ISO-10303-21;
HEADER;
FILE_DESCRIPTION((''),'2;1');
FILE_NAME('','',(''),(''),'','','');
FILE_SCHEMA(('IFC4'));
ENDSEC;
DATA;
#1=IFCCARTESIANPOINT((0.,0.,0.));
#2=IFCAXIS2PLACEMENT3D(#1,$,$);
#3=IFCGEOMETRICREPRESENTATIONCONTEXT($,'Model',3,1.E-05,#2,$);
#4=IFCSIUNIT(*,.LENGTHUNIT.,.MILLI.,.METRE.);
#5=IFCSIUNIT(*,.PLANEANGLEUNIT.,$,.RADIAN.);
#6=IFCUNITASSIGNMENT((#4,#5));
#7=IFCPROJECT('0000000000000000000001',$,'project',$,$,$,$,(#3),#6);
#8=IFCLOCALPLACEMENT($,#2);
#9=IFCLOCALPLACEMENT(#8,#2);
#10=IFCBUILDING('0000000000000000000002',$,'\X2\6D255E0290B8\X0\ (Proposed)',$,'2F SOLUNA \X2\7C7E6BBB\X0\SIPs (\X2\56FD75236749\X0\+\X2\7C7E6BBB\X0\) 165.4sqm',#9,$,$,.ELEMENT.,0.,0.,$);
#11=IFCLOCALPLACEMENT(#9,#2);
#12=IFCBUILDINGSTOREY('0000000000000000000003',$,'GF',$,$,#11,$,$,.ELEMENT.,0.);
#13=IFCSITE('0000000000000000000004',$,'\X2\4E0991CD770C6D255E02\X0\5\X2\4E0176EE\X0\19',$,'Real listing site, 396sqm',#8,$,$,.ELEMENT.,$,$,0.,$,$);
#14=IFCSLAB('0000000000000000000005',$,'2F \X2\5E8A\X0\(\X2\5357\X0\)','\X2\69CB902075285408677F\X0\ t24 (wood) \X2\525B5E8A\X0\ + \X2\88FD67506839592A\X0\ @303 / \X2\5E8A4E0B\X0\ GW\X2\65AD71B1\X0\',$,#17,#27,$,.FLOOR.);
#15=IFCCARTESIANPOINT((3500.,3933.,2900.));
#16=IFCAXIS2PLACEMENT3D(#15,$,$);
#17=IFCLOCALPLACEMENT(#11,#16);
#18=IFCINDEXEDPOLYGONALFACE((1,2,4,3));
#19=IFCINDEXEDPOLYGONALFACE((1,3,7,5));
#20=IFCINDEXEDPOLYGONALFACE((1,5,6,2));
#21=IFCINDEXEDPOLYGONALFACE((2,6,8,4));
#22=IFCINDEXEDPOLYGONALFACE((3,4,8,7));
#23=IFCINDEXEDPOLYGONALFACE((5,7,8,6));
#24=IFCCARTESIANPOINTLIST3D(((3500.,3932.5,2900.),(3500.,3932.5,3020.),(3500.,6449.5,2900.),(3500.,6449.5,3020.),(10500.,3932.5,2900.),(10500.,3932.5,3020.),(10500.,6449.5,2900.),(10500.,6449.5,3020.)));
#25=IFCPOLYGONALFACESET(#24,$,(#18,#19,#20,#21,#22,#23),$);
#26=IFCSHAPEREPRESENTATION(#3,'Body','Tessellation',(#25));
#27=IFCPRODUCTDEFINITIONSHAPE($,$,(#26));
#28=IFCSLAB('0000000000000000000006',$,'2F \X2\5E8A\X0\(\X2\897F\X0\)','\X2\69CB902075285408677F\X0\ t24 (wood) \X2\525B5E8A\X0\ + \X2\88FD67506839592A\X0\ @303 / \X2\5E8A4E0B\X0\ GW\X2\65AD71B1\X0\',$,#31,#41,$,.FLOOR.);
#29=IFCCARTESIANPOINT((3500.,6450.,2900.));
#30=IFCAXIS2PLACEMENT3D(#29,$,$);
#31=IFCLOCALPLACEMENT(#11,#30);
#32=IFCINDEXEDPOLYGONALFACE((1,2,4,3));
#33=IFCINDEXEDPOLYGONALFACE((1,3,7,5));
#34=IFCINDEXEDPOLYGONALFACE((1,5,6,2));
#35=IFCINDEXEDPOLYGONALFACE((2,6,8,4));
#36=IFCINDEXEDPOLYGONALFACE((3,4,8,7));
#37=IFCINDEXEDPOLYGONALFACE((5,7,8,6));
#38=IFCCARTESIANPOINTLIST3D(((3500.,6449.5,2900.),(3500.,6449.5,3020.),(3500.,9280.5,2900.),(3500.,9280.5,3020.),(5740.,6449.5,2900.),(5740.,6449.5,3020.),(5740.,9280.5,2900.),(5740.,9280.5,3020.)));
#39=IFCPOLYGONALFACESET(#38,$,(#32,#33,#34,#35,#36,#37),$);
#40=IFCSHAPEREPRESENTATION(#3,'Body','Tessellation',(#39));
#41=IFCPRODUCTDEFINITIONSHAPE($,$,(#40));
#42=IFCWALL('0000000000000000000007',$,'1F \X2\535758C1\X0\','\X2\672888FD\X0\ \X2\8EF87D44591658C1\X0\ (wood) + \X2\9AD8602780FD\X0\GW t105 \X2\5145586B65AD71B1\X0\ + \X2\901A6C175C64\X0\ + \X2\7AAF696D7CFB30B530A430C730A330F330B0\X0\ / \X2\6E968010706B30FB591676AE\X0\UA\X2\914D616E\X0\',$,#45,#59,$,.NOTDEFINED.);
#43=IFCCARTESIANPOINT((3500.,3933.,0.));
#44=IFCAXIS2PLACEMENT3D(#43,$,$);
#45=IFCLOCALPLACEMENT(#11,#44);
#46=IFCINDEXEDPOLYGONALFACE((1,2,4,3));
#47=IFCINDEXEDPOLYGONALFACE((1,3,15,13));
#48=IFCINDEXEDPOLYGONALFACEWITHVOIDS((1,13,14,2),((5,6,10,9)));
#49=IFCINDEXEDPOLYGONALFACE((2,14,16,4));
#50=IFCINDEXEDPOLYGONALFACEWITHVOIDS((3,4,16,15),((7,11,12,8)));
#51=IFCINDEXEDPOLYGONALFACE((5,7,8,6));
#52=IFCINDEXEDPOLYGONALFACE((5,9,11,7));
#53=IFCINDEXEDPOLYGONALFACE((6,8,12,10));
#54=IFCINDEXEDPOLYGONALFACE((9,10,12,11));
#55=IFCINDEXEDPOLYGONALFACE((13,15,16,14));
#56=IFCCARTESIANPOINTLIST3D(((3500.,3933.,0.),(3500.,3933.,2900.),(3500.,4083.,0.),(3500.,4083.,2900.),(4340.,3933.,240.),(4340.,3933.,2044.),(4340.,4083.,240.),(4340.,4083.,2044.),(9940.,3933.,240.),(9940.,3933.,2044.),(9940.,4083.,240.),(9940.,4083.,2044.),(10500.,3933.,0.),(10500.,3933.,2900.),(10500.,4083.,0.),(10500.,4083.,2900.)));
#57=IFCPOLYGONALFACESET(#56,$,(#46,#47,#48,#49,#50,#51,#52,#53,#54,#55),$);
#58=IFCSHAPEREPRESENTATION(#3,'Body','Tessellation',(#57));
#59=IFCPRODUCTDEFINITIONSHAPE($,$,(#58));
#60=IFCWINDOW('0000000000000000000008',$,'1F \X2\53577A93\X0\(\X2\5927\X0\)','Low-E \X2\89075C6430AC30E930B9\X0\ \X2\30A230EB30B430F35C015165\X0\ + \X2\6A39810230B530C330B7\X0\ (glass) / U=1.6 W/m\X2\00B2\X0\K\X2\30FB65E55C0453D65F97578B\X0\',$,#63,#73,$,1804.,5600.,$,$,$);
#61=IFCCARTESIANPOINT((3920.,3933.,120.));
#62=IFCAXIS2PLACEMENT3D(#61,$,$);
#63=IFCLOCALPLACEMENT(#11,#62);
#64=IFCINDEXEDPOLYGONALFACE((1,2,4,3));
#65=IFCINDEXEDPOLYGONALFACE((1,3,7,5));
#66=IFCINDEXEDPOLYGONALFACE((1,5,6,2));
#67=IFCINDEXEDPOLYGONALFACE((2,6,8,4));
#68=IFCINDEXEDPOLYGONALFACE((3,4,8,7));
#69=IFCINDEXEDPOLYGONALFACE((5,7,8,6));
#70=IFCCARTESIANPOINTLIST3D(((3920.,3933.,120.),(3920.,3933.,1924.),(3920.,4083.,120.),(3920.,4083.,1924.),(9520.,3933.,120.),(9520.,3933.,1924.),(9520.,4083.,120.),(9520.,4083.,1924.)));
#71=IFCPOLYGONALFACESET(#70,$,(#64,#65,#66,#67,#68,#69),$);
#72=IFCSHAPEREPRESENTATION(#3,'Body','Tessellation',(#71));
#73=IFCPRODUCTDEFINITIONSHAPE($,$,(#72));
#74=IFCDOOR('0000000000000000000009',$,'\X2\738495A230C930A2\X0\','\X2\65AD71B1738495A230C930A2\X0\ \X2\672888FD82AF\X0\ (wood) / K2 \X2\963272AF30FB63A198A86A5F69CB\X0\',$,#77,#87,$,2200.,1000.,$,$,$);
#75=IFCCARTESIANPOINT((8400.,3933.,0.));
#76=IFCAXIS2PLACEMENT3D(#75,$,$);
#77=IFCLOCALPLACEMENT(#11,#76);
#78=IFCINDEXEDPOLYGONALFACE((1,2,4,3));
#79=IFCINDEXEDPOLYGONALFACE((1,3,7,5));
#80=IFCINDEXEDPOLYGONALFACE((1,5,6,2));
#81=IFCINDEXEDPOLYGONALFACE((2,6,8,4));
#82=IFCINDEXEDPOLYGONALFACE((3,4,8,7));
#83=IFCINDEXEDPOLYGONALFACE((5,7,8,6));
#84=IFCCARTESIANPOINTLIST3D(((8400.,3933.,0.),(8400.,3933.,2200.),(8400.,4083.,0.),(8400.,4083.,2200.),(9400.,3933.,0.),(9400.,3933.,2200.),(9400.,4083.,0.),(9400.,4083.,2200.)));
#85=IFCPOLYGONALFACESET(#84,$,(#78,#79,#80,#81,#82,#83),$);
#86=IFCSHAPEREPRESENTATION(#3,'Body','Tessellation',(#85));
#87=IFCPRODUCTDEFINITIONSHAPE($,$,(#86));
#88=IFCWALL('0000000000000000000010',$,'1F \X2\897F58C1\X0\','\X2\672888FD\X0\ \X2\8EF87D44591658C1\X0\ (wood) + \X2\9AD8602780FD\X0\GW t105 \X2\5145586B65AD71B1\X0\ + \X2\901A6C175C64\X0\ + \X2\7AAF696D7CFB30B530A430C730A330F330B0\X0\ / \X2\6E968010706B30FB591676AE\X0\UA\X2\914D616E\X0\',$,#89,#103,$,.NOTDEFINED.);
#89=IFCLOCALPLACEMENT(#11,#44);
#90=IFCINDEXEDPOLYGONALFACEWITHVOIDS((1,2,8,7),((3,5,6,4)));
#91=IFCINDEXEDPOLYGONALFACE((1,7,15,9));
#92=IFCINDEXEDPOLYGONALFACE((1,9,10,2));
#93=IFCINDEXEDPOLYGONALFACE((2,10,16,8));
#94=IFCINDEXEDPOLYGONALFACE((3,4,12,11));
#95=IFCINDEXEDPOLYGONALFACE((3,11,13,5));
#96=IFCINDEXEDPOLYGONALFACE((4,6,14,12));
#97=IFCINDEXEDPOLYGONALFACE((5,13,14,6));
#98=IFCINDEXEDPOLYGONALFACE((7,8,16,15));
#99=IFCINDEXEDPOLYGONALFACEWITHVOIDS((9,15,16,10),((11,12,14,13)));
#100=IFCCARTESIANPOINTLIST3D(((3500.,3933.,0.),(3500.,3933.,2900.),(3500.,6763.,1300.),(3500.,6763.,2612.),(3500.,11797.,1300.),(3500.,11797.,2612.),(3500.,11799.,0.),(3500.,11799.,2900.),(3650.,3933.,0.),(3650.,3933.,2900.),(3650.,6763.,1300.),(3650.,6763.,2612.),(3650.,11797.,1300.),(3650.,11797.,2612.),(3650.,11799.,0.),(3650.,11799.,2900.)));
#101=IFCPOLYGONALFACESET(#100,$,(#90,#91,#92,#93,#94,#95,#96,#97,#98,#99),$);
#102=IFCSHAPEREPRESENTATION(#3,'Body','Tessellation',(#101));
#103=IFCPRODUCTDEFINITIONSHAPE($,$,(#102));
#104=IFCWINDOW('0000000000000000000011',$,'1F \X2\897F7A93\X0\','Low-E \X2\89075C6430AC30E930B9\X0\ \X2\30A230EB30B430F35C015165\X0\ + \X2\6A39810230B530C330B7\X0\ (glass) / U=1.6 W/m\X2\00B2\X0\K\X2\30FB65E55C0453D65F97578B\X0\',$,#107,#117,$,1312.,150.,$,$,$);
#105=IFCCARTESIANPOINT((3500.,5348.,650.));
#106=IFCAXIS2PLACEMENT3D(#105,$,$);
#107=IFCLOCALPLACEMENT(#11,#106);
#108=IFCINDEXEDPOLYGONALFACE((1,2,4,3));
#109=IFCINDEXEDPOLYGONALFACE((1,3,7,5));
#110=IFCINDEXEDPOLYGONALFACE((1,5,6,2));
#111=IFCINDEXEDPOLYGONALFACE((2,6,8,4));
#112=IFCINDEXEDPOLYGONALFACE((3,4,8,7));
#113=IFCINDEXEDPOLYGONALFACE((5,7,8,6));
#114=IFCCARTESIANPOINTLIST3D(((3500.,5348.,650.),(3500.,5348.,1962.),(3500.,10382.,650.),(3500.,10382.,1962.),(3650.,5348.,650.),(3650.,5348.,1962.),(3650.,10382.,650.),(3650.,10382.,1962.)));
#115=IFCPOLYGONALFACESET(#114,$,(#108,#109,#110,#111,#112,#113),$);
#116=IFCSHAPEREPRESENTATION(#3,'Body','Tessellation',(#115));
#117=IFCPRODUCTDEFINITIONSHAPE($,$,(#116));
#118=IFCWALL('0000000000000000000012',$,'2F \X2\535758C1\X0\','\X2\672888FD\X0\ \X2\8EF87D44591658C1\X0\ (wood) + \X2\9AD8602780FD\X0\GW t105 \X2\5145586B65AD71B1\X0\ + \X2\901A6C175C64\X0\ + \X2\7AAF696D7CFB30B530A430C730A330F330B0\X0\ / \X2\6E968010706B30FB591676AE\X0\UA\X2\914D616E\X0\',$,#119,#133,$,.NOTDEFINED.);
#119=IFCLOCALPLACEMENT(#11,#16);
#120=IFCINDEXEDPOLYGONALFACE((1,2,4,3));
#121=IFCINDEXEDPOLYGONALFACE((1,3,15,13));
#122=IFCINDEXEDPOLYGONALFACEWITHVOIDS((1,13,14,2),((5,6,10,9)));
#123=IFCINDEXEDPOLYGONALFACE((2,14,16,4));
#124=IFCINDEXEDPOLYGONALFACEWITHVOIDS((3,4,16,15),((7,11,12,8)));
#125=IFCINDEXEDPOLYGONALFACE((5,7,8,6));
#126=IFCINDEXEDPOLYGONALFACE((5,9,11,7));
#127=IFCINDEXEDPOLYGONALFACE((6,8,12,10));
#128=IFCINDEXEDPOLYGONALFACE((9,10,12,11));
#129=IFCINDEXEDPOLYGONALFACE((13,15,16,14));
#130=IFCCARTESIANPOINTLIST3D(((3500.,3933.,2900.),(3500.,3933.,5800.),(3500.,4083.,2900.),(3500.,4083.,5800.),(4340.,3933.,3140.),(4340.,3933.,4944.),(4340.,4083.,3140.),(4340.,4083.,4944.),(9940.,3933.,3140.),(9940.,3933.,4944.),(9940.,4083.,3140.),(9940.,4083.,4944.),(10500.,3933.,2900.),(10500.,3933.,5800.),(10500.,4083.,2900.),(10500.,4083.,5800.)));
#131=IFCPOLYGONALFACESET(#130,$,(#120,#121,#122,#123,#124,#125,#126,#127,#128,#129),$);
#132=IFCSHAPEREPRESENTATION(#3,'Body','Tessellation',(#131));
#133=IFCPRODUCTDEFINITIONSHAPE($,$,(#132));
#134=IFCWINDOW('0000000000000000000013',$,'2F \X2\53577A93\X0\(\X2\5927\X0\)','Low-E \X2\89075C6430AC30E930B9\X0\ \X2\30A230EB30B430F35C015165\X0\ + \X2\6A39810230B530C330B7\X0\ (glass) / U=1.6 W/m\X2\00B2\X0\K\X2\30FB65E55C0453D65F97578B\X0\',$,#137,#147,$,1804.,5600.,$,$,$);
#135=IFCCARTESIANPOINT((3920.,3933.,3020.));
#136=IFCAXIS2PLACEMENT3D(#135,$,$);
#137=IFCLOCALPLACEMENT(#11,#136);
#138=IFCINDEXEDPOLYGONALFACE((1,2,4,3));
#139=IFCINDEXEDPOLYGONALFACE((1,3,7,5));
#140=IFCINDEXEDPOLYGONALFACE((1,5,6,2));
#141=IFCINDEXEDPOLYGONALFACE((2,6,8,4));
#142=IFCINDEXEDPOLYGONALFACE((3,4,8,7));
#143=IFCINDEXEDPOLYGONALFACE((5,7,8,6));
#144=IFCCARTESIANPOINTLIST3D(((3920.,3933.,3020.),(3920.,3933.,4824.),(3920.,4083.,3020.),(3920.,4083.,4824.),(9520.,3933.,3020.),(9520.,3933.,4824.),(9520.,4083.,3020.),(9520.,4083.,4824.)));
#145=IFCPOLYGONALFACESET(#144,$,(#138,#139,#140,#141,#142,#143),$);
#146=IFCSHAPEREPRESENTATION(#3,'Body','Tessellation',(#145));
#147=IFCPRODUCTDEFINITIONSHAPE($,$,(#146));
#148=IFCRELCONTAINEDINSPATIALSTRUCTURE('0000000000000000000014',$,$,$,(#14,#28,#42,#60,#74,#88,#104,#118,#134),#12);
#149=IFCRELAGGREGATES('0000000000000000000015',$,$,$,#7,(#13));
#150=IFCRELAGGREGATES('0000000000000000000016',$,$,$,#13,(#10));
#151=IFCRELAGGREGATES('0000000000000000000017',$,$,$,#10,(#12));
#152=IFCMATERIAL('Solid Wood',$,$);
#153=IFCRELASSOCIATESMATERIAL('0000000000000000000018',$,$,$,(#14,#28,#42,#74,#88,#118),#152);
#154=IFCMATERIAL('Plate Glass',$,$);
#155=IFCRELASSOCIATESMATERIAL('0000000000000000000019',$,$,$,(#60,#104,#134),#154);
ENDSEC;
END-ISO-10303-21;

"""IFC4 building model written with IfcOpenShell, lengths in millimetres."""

from ifc_helpers import new_model, si_unit, frame, frame_2d, origin, place, context, project, spatial, rectangle, extrude, material, element, fill, save


model = new_model("IFC4")

# Units and contexts
model_context = context("Model", 3, precision=1e-05, world=origin())
ifc_project = project(units=[si_unit("LENGTHUNIT", "METRE", prefix="MILLI"), si_unit("PLANEANGLEUNIT", "RADIAN")], contexts=[model_context])

# Site, building, storey
site_placement = place(None, origin())
site = spatial("IfcSite", under=ifc_project, at=site_placement, Name="三重県津市5丁目19", ObjectType="Real listing site, 396sqm", CompositionType="ELEMENT", RefElevation=0.0)
building_placement = place(site_placement, origin())
building = spatial("IfcBuilding", under=site, at=building_placement, Name="津市邸 (Proposed)", ObjectType="2F SOLUNA 籾殻SIPs (国産杉+籾殻) 165.4sqm", CompositionType="ELEMENT", ElevationOfRefHeight=0.0, ElevationOfTerrain=0.0)
storey_placement = place(building_placement, origin())
storey = spatial("IfcBuildingStorey", under=building, at=storey_placement, Name="GF", CompositionType="ELEMENT", Elevation=0.0)

# Slabs
ifc_material_1 = material(Name="Solid Wood")
slab_1_placement = place(storey_placement, frame((3500.0, 3933.0, 2900.0)))
element("IfcSlab", 1, at=slab_1_placement, inside=storey, material=ifc_material_1, Name="2F 床(南)", Description="構造用合板 t24 (wood) 剛床 + 製材根太 @303 / 床下 GW断熱", PredefinedType="FLOOR", context=model_context, shape_type="SweptSolid", body=[
    extrude(rectangle(XDim=7000.0, YDim=2517.0, at=frame_2d((3500.0, 1258.0))), frame((3500.0, 3933.0, 2900.0)), (0.0, 0.0, 1.0), 120.0),
])
slab_2_placement = place(storey_placement, frame((3500.0, 6450.0, 2900.0)))
element("IfcSlab", 2, at=slab_2_placement, inside=storey, material=ifc_material_1, Name="2F 床(西)", Description="構造用合板 t24 (wood) 剛床 + 製材根太 @303 / 床下 GW断熱", PredefinedType="FLOOR", context=model_context, shape_type="SweptSolid", body=[
    extrude(rectangle(XDim=2240.0, YDim=2831.0, at=frame_2d((1120.0, 1415.0))), frame((3500.0, 6450.0, 2900.0)), (0.0, 0.0, 1.0), 120.0),
])

# Wall, openings, window, door
wall_1_placement = place(storey_placement, frame((3500.0, 3933.0, 0.0)))
wall_1 = element("IfcWall", 3, at=wall_1_placement, inside=storey, material=ifc_material_1, Name="1F 南壁", Description="木製 軸組外壁 (wood) + 高性能GW t105 充填断熱 + 通気層 + 窯業系サイディング / 準耐火・外皮UA配慮", PredefinedType="NOTDEFINED", context=model_context, shape_type="SweptSolid", body=[
    extrude(rectangle(XDim=7000.0, YDim=150.0, at=frame_2d((3500.0, 75.0))), frame((3500.0, 3933.0, 0.0)), (0.0, 0.0, 1.0), 2900.0),
])
opening_1_placement = place(storey_placement, frame((3920.0, 3933.0, 120.0)))
opening_1 = element("IfcOpeningElement", 4, at=opening_1_placement, cuts=wall_1, PredefinedType="NOTDEFINED", context=model_context, shape_type="SweptSolid", body=[
    extrude(rectangle(XDim=5600.0, YDim=150.0, at=frame_2d((2800.0, 75.0))), frame((3920.0, 3933.0, 120.0)), (0.0, 0.0, 1.0), 1804.0),
])
opening_2_placement = place(storey_placement, frame((8400.0, 3933.0, 0.0)))
opening_2 = element("IfcOpeningElement", 5, at=opening_2_placement, cuts=wall_1, PredefinedType="NOTDEFINED", context=model_context, shape_type="SweptSolid", body=[
    extrude(rectangle(XDim=1000.0, YDim=150.0, at=frame_2d((500.0, 75.0))), frame((8400.0, 3933.0, 0.0)), (0.0, 0.0, 1.0), 2200.0),
])
ifc_material_2 = material(Name="Plate Glass")
window_1_placement = place(storey_placement, frame((3920.0, 3933.0, 120.0)))
window_1 = element("IfcWindow", 6, at=window_1_placement, inside=storey, material=ifc_material_2, Name="1F 南窓(大)", Description="Low-E 複層ガラス アルゴン封入 + 樹脂サッシ (glass) / U=1.6 W/m²K・日射取得型", OverallHeight=1804.0, OverallWidth=5600.0, context=model_context, shape_type="SweptSolid", body=[
    extrude(rectangle(XDim=5600.0, YDim=150.0, at=frame_2d((2800.0, 75.0))), frame((3920.0, 3933.0, 120.0)), (0.0, 0.0, 1.0), 1804.0),
])
fill(opening_1, window_1)
door_placement = place(storey_placement, frame((8400.0, 3933.0, 0.0)))
door = element("IfcDoor", 7, at=door_placement, inside=storey, material=ifc_material_1, Name="玄関ドア", Description="断熱玄関ドア 木製芯 (wood) / K2 防犯・採風機構", OverallHeight=2200.0, OverallWidth=1000.0, context=model_context, shape_type="SweptSolid", body=[
    extrude(rectangle(XDim=1000.0, YDim=150.0, at=frame_2d((500.0, 75.0))), frame((8400.0, 3933.0, 0.0)), (0.0, 0.0, 1.0), 2200.0),
])
fill(opening_2, door)

# Walls, openings, windows
wall_2_placement = place(storey_placement, frame((3500.0, 3933.0, 0.0)))
wall_2 = element("IfcWall", 8, at=wall_2_placement, inside=storey, material=ifc_material_1, Name="1F 西壁", Description="木製 軸組外壁 (wood) + 高性能GW t105 充填断熱 + 通気層 + 窯業系サイディング / 準耐火・外皮UA配慮", PredefinedType="NOTDEFINED", context=model_context, shape_type="SweptSolid", body=[
    extrude(rectangle(XDim=150.0, YDim=7866.0, at=frame_2d((75.0, 3933.0))), frame((3500.0, 3933.0, 0.0)), (0.0, 0.0, 1.0), 2900.0),
])
opening_3_placement = place(storey_placement, frame((3500.0, 5348.0, 650.0)))
opening_3 = element("IfcOpeningElement", 9, at=opening_3_placement, cuts=wall_2, PredefinedType="NOTDEFINED", context=model_context, shape_type="SweptSolid", body=[
    extrude(rectangle(XDim=150.0, YDim=5034.0, at=frame_2d((75.0, 2517.0))), frame((3500.0, 5348.0, 650.0)), (0.0, 0.0, 1.0), 1312.0),
])
window_2_placement = place(storey_placement, frame((3500.0, 5348.0, 650.0)))
window_2 = element("IfcWindow", 10, at=window_2_placement, inside=storey, material=ifc_material_2, Name="1F 西窓", Description="Low-E 複層ガラス アルゴン封入 + 樹脂サッシ (glass) / U=1.6 W/m²K・日射取得型", OverallHeight=1312.0, OverallWidth=150.0, context=model_context, shape_type="SweptSolid", body=[
    extrude(rectangle(XDim=150.0, YDim=5034.0, at=frame_2d((75.0, 2517.0))), frame((3500.0, 5348.0, 650.0)), (0.0, 0.0, 1.0), 1312.0),
])
fill(opening_3, window_2)
wall_3_placement = place(storey_placement, frame((3500.0, 3933.0, 2900.0)))
wall_3 = element("IfcWall", 11, at=wall_3_placement, inside=storey, material=ifc_material_1, Name="2F 南壁", Description="木製 軸組外壁 (wood) + 高性能GW t105 充填断熱 + 通気層 + 窯業系サイディング / 準耐火・外皮UA配慮", PredefinedType="NOTDEFINED", context=model_context, shape_type="SweptSolid", body=[
    extrude(rectangle(XDim=7000.0, YDim=150.0, at=frame_2d((3500.0, 75.0))), frame((3500.0, 3933.0, 2900.0)), (0.0, 0.0, 1.0), 2900.0),
])
opening_4_placement = place(storey_placement, frame((3920.0, 3933.0, 3020.0)))
opening_4 = element("IfcOpeningElement", 12, at=opening_4_placement, cuts=wall_3, PredefinedType="NOTDEFINED", context=model_context, shape_type="SweptSolid", body=[
    extrude(rectangle(XDim=5600.0, YDim=150.0, at=frame_2d((2800.0, 75.0))), frame((3920.0, 3933.0, 3020.0)), (0.0, 0.0, 1.0), 1804.0),
])
window_3_placement = place(storey_placement, frame((3920.0, 3933.0, 3020.0)))
window_3 = element("IfcWindow", 13, at=window_3_placement, inside=storey, material=ifc_material_2, Name="2F 南窓(大)", Description="Low-E 複層ガラス アルゴン封入 + 樹脂サッシ (glass) / U=1.6 W/m²K・日射取得型", OverallHeight=1804.0, OverallWidth=5600.0, context=model_context, shape_type="SweptSolid", body=[
    extrude(rectangle(XDim=5600.0, YDim=150.0, at=frame_2d((2800.0, 75.0))), frame((3920.0, 3933.0, 3020.0)), (0.0, 0.0, 1.0), 1804.0),
])
fill(opening_4, window_3)

save(model, "model.ifc")
